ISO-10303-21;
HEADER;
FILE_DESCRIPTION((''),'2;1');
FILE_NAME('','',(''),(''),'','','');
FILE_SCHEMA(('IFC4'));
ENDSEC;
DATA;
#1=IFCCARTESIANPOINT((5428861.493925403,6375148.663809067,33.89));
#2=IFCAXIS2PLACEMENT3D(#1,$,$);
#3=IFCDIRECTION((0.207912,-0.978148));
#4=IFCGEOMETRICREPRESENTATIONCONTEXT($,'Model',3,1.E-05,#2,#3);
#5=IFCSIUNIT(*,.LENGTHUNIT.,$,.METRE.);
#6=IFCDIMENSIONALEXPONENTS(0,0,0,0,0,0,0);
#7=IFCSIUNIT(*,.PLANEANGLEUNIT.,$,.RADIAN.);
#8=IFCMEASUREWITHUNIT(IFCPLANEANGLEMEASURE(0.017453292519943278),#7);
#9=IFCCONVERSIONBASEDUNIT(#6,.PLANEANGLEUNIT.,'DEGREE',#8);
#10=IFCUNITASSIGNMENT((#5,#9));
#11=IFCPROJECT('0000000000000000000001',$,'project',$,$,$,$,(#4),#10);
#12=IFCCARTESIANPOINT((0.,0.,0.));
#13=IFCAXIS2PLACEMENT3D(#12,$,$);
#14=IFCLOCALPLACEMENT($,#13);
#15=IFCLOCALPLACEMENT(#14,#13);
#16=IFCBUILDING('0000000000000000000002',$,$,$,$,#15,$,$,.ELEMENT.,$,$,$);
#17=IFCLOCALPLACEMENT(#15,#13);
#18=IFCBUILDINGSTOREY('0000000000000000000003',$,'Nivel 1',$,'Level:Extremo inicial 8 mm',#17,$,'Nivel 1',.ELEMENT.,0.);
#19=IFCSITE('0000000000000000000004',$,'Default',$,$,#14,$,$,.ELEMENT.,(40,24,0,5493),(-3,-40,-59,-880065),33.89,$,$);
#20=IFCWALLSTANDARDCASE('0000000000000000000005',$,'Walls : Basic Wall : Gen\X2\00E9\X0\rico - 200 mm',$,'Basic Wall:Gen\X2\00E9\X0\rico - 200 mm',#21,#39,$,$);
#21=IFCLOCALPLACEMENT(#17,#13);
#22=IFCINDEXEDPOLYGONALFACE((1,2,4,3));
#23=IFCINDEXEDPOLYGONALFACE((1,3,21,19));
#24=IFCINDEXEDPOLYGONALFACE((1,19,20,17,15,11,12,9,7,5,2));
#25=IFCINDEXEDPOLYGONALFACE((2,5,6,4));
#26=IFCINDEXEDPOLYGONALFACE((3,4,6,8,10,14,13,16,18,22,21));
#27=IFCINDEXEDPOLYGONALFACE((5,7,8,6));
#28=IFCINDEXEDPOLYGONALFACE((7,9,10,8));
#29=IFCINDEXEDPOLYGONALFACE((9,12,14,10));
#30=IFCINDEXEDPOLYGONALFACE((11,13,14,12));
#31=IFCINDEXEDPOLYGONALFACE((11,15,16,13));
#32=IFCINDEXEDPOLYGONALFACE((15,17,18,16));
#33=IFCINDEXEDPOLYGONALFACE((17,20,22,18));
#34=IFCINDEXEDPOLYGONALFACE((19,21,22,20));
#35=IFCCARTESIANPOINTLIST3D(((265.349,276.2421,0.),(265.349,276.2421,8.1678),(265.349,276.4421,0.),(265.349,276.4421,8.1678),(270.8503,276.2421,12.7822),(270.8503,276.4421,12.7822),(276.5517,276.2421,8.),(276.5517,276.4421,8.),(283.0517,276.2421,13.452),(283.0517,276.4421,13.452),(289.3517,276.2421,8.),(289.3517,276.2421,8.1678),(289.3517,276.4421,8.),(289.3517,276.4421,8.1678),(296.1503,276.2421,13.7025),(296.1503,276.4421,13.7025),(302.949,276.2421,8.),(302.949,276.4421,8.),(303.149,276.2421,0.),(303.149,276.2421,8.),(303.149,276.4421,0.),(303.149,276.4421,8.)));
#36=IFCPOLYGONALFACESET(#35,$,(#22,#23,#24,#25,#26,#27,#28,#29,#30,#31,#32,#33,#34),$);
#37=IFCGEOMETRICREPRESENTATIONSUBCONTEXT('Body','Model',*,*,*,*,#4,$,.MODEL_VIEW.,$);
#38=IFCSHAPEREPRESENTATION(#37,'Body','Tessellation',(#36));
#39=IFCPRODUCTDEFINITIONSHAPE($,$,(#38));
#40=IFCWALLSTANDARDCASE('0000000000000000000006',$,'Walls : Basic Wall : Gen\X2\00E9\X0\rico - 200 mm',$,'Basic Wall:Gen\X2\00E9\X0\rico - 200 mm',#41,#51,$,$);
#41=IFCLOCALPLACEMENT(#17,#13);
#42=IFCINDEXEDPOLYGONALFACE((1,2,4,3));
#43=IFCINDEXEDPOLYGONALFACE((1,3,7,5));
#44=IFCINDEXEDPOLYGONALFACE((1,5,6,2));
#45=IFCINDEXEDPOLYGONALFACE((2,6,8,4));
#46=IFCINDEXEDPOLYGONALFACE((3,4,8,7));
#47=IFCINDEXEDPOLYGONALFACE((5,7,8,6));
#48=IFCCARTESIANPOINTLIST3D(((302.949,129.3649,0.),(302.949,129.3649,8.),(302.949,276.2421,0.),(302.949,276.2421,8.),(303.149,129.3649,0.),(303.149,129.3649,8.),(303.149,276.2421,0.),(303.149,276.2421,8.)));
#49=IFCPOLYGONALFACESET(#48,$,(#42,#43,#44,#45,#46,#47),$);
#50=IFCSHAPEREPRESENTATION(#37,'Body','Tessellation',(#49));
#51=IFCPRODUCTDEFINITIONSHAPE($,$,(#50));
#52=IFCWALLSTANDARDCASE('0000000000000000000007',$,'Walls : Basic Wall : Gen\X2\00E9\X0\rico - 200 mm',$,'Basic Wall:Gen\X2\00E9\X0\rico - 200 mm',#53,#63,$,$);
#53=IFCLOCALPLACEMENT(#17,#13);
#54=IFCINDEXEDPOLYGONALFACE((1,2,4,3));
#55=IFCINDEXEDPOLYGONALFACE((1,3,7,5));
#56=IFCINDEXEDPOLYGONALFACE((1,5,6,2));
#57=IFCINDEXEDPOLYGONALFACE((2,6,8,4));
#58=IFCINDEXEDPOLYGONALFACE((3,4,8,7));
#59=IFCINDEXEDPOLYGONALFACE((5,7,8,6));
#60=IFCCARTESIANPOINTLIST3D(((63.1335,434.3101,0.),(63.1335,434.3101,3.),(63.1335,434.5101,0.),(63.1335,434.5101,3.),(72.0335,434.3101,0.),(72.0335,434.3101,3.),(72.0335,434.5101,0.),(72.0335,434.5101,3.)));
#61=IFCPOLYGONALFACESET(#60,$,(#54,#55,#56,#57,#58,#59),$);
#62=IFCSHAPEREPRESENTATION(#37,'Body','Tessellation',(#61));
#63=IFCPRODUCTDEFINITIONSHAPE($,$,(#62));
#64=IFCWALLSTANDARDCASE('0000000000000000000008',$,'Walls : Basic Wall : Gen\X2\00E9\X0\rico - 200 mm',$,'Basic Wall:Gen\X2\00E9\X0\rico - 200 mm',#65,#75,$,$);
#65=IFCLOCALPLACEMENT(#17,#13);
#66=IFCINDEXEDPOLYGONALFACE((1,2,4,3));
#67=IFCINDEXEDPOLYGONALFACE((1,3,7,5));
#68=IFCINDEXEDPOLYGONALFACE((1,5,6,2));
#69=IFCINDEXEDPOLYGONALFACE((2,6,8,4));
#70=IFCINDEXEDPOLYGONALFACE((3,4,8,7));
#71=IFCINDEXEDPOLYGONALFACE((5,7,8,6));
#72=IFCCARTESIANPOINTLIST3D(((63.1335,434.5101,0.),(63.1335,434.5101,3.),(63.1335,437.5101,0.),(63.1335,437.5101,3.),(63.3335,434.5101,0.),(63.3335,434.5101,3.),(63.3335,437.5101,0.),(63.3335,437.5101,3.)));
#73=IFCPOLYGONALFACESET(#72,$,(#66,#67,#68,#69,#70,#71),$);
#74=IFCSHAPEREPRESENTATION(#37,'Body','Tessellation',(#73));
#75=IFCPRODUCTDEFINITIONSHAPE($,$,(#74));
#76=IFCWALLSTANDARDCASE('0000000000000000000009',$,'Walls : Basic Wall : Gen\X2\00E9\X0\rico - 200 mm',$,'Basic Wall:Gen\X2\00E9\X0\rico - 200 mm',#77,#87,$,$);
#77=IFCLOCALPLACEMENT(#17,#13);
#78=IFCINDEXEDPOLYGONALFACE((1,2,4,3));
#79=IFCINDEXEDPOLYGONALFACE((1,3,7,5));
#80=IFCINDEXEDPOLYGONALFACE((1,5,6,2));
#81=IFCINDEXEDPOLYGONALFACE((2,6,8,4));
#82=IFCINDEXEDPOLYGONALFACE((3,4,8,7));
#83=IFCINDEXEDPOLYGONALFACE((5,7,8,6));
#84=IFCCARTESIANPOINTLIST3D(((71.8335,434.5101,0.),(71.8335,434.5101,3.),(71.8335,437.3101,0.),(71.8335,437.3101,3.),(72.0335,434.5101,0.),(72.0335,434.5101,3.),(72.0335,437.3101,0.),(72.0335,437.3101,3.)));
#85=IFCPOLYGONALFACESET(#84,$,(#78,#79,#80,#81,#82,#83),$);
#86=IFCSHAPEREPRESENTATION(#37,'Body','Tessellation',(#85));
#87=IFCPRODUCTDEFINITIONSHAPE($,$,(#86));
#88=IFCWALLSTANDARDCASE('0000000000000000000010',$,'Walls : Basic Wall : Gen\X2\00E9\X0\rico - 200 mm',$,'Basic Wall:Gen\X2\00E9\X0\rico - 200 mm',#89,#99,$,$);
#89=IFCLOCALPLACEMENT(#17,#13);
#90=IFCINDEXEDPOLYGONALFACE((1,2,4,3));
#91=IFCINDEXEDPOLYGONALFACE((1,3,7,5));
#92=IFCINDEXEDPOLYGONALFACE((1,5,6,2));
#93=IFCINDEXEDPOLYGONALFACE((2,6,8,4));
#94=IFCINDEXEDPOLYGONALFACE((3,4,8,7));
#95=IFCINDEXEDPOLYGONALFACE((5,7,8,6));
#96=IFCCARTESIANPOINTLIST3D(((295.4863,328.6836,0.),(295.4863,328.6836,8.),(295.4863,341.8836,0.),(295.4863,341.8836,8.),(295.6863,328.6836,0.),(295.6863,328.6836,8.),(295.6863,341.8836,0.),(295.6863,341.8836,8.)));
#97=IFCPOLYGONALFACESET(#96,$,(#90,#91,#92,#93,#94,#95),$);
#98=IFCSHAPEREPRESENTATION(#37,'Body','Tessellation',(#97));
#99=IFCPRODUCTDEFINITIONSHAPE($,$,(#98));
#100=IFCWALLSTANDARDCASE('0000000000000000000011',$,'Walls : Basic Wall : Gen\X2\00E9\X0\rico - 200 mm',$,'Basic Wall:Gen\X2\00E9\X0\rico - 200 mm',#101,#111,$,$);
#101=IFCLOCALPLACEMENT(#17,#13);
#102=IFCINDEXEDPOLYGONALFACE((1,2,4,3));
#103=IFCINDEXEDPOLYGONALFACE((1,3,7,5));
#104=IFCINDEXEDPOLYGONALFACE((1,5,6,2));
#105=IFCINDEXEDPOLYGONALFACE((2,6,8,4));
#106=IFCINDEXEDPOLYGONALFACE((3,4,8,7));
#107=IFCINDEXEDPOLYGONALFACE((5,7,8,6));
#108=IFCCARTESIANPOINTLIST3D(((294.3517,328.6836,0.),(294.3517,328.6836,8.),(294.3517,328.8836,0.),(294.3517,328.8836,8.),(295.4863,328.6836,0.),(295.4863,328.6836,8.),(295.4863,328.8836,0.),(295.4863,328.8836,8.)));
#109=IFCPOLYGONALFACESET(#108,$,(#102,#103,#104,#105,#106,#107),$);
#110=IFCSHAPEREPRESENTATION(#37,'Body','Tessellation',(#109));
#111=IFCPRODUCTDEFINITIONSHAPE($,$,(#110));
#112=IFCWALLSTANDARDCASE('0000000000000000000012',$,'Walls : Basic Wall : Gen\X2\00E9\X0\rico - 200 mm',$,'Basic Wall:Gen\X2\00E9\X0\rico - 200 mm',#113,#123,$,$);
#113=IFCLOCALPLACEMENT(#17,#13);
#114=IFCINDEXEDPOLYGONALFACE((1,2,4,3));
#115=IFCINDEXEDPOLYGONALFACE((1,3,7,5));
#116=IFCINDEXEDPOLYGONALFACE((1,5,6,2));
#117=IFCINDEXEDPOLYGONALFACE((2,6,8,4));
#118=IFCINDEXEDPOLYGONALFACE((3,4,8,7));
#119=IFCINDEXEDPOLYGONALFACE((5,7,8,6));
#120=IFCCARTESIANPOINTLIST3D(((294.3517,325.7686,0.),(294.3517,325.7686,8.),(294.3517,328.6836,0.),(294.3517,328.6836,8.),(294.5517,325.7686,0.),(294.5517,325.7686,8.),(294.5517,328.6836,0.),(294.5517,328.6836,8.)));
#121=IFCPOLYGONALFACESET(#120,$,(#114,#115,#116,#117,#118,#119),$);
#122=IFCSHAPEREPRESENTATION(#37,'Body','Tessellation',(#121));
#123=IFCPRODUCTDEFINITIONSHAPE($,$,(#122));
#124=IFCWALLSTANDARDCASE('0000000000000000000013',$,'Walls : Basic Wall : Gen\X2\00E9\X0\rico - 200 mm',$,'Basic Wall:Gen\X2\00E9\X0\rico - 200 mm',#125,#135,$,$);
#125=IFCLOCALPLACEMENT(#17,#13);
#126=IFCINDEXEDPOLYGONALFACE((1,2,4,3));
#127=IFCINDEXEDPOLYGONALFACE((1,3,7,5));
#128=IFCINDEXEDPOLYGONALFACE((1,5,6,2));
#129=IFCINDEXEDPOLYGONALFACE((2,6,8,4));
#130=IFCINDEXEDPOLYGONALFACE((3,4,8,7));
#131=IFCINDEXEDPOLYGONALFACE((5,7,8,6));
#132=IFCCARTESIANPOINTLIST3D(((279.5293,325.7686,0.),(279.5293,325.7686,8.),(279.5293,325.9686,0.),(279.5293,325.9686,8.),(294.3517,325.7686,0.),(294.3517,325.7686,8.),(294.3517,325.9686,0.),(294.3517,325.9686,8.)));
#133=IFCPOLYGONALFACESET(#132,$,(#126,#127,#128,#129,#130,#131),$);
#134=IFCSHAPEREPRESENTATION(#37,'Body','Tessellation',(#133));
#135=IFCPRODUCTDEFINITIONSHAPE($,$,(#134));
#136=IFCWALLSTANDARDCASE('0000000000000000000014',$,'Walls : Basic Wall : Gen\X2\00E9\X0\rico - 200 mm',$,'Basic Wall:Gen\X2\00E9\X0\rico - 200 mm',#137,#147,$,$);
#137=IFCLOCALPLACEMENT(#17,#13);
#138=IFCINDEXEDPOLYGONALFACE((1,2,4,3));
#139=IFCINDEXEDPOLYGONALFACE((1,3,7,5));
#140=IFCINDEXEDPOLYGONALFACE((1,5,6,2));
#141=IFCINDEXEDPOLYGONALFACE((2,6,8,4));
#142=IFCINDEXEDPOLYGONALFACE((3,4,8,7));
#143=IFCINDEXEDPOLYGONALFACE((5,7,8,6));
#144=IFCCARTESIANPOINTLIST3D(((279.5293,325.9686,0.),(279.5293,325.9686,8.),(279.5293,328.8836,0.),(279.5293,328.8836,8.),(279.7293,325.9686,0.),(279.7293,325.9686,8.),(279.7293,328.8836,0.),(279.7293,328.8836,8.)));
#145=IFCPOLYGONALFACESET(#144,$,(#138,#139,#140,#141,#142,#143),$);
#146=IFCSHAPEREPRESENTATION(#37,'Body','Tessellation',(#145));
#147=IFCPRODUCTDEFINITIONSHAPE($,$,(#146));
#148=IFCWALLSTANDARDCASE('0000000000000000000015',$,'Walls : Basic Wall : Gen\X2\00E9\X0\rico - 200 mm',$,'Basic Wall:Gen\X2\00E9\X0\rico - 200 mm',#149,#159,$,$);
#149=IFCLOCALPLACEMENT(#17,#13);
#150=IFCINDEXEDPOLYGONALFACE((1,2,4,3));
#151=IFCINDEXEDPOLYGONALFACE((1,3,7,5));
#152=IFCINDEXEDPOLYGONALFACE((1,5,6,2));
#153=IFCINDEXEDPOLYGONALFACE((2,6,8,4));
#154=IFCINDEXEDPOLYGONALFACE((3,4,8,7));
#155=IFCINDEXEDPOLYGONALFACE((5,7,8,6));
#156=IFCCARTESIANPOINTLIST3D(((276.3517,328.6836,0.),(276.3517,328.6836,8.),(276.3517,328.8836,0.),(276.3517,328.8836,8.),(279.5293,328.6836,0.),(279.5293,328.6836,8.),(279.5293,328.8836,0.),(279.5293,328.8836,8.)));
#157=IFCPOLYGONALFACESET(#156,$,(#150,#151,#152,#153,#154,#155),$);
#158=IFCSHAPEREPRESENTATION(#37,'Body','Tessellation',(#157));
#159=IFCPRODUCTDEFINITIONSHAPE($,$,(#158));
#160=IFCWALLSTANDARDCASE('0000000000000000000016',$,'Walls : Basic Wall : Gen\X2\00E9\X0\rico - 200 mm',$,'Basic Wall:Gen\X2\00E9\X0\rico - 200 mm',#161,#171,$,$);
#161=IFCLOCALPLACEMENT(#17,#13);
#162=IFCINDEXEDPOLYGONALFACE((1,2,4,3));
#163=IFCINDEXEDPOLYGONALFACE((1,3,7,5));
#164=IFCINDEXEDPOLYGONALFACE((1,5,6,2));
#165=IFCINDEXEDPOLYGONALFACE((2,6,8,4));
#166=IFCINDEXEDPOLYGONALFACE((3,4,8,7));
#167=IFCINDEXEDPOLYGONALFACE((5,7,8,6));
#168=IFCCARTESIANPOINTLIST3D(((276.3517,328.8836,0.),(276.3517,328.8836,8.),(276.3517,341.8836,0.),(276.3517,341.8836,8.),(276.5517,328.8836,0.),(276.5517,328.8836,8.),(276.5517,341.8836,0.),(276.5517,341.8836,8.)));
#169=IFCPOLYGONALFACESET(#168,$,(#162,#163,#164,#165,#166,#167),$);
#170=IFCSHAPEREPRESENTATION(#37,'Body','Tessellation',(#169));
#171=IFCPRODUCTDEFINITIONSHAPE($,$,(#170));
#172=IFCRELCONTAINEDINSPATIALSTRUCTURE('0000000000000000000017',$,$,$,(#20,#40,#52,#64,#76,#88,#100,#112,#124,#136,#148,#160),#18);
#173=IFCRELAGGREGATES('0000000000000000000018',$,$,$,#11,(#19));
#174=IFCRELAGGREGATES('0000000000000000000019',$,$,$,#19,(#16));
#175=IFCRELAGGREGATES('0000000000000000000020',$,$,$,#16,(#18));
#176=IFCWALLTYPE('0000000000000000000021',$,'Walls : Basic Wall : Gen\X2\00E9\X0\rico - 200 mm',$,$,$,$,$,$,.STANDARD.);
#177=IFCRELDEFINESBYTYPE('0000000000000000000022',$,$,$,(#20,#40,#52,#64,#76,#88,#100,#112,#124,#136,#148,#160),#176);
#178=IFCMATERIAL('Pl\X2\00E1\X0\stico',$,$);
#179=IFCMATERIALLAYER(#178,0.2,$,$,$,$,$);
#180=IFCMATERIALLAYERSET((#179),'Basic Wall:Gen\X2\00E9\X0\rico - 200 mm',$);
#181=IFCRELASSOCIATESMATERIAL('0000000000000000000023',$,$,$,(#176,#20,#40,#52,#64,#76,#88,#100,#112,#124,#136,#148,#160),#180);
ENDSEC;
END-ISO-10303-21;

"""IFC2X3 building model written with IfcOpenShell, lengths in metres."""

from ifc_helpers import new_model, entity, si_unit, converted_unit, direction, frame, frame_2d, origin, place, context, subcontext, project, spatial, polyline, rectangle, extrude, clip, bounded_halfspace, material, layer, layer_set, layer_usage, type_object, element, save


model = new_model("IFC2X3")

# Units and contexts
model_context = context("Model", 3, precision=1e-05, world=frame((5428861.493925403, 6375148.663809067, 33.89)), true_north=direction((0.207912, -0.978148)))
body_context = subcontext(model_context, "Body", "Model", "MODEL_VIEW")
ifc_project = project(units=[si_unit("LENGTHUNIT", "METRE"), converted_unit("PLANEANGLEUNIT", "DEGREE", entity("IfcPlaneAngleMeasure", 0.017453292519943278), si_unit("PLANEANGLEUNIT", "RADIAN"), dimensions=[0, 0, 0, 0, 0, 0, 0])], contexts=[model_context])

# Site, building, storey
site_placement = place(None, origin())
site = spatial("IfcSite", under=ifc_project, at=site_placement, Name="Default", CompositionType="ELEMENT", RefLatitude=(40, 24, 0, 5493), RefLongitude=(-3, -40, -59, -880065), RefElevation=33.89)
building_placement = place(site_placement, origin())
building = spatial("IfcBuilding", under=site, at=building_placement, CompositionType="ELEMENT")
storey_placement = place(building_placement, origin())
storey = spatial("IfcBuildingStorey", under=building, at=storey_placement, Name="Nivel 1", ObjectType="Level:Extremo inicial 8 mm", LongName="Nivel 1", CompositionType="ELEMENT", Elevation=0.0)

# Walls
ifc_material_1 = material(Name="Plástico")
ifc_layer_1 = layer(ifc_material_1, 0.2)
ifc_layer_set_1 = layer_set([ifc_layer_1], Name="Basic Wall:Genérico - 200 mm")
ifc_layer_usage_1 = layer_usage(ifc_layer_set_1, "AXIS2", "NEGATIVE", 0.1)
wall_type = type_object("IfcWallType", Name="Walls : Basic Wall : Genérico - 200 mm", PredefinedType="STANDARD", material=ifc_layer_set_1)
wall_1_placement = place(storey_placement, frame((265.349, 276.3421, 0.0)))
element("IfcWallStandardCase", 1, at=wall_1_placement, inside=storey, type_object=wall_type, material=ifc_layer_usage_1, Name="Walls : Basic Wall : Genérico - 200 mm", ObjectType="Basic Wall:Genérico - 200 mm", context=body_context, shape_type="Clipping", body=[
    clip(clip(clip(clip(clip(clip(clip(extrude(rectangle(XDim=37.8, YDim=0.2, at=frame_2d((18.9, 0.0), x_axis=(-1.0, 0.0))), origin(), (0.0, 0.0, 1.0), 13.7025), bounded_halfspace(frame((0.0, -0.1, 8.1678), z_axis=(-0.642641, 0.0, 0.766167), x_axis=(0.0, -1.0, 0.0)), False, frame((0.0, -0.1, 8.1678)), polyline([(0.0, 0.0), (5.5014, 0.0), (5.5014, 0.2), (0.0, 0.2), (0.0, 0.0)]))), bounded_halfspace(frame((11.2027, -0.1, 8.0), z_axis=(-0.642641, 0.0, 0.766167), x_axis=(0.0, -1.0, 0.0)), False, frame((11.2027, -0.1, 8.0)), polyline([(0.0, 0.0), (6.5, 0.0), (6.5, 0.2), (0.0, 0.2), (0.0, 0.0)]))), bounded_halfspace(frame((30.8014, 0.1, 13.7025), z_axis=(-0.642641, 0.0, 0.766167), x_axis=(0.0, -1.0, 0.0)), False, frame((30.8014, 0.1, 13.7025)), polyline([(0.0, 0.0), (-6.7986, 0.0), (-6.7986, -0.2), (0.0, -0.2), (0.0, 0.0)]))), bounded_halfspace(frame((5.5014, -0.1, 12.7822), z_axis=(0.642641, 0.0, 0.766167), x_axis=(0.0, 1.0, 0.0)), False, frame((5.5014, -0.1, 12.7822)), polyline([(0.0, 0.0), (5.7014, 0.0), (5.7014, 0.2), (0.0, 0.2), (0.0, 0.0)]))), bounded_halfspace(frame((17.7027, -0.1, 13.452), z_axis=(0.642641, 0.0, 0.766167), x_axis=(0.0, 1.0, 0.0)), False, frame((17.7027, -0.1, 13.452)), polyline([(0.0, 0.0), (6.3, 0.0), (6.3, 0.2), (0.0, 0.2), (0.0, 0.0)]))), bounded_halfspace(frame((37.6, -0.1, 8.0), z_axis=(0.642641, 0.0, 0.766167), x_axis=(0.0, 1.0, 0.0)), False, frame((37.6, -0.1, 8.0)), polyline([(0.0, 0.0), (0.0, 0.2), (-6.7986, 0.2), (-6.7986, 0.0), (0.0, 0.0)]))), bounded_halfspace(frame((37.6, -0.1, 8.0), z_axis=(0.0, 0.0, 1.0), x_axis=(0.0, 1.0, 0.0)), False, frame((37.6, -0.1, 8.0)), polyline([(0.0, 0.0), (0.2, 0.0), (0.2, 0.2), (0.0, 0.2), (0.0, 0.0)]))),
])
ifc_layer_usage_2 = layer_usage(ifc_layer_set_1, "AXIS2", "NEGATIVE", 0.1)
wall_2_placement = place(storey_placement, frame((303.049, 276.2421, 0.0), z_axis=(0.0, 0.0, 1.0), x_axis=(0.0, -1.0, 0.0)))
element("IfcWallStandardCase", 2, at=wall_2_placement, inside=storey, type_object=wall_type, material=ifc_layer_usage_2, Name="Walls : Basic Wall : Genérico - 200 mm", ObjectType="Basic Wall:Genérico - 200 mm", context=body_context, shape_type="SweptSolid", body=[
    extrude(rectangle(XDim=146.8772, YDim=0.2, at=frame_2d((73.4386, 0.0), x_axis=(-1.0, 0.0))), origin(), (0.0, 0.0, 1.0), 8.0),
])
ifc_layer_usage_3 = layer_usage(ifc_layer_set_1, "AXIS2", "NEGATIVE", 0.1)
wall_3_placement = place(storey_placement, frame((72.0335, 434.4101, 0.0), z_axis=(0.0, 0.0, 1.0), x_axis=(-1.0, 0.0, 0.0)))
element("IfcWallStandardCase", 3, at=wall_3_placement, inside=storey, type_object=wall_type, material=ifc_layer_usage_3, Name="Walls : Basic Wall : Genérico - 200 mm", ObjectType="Basic Wall:Genérico - 200 mm", context=body_context, shape_type="SweptSolid", body=[
    extrude(rectangle(XDim=8.9, YDim=0.2, at=frame_2d((4.45, 0.0), x_axis=(-1.0, 0.0))), origin(), (0.0, 0.0, 1.0), 3.0),
])
ifc_layer_usage_4 = layer_usage(ifc_layer_set_1, "AXIS2", "POSITIVE", -0.1)
wall_4_placement = place(storey_placement, frame((63.2335, 434.5101, 0.0), z_axis=(0.0, 0.0, 1.0), x_axis=(0.0, 1.0, 0.0)))
element("IfcWallStandardCase", 4, at=wall_4_placement, inside=storey, type_object=wall_type, material=ifc_layer_usage_4, Name="Walls : Basic Wall : Genérico - 200 mm", ObjectType="Basic Wall:Genérico - 200 mm", context=body_context, shape_type="SweptSolid", body=[
    extrude(rectangle(XDim=3.0, YDim=0.2, at=frame_2d((1.5, 0.0), x_axis=(-1.0, 0.0))), origin(), (0.0, 0.0, 1.0), 3.0),
])
ifc_layer_usage_5 = layer_usage(ifc_layer_set_1, "AXIS2", "NEGATIVE", 0.1)
wall_5_placement = place(storey_placement, frame((71.9335, 437.3101, 0.0), z_axis=(0.0, 0.0, 1.0), x_axis=(0.0, -1.0, 0.0)))
element("IfcWallStandardCase", 5, at=wall_5_placement, inside=storey, type_object=wall_type, material=ifc_layer_usage_5, Name="Walls : Basic Wall : Genérico - 200 mm", ObjectType="Basic Wall:Genérico - 200 mm", context=body_context, shape_type="SweptSolid", body=[
    extrude(rectangle(XDim=2.8, YDim=0.2, at=frame_2d((1.4, 0.0), x_axis=(-1.0, 0.0))), origin(), (0.0, 0.0, 1.0), 3.0),
])
ifc_layer_usage_6 = layer_usage(ifc_layer_set_1, "AXIS2", "NEGATIVE", 0.1)
wall_6_placement = place(storey_placement, frame((295.5863, 341.8836, 0.0), z_axis=(0.0, 0.0, 1.0), x_axis=(0.0, -1.0, 0.0)))
element("IfcWallStandardCase", 6, at=wall_6_placement, inside=storey, type_object=wall_type, material=ifc_layer_usage_6, Name="Walls : Basic Wall : Genérico - 200 mm", ObjectType="Basic Wall:Genérico - 200 mm", context=body_context, shape_type="SweptSolid", body=[
    extrude(rectangle(XDim=13.2, YDim=0.2, at=frame_2d((6.6, 0.0), x_axis=(-1.0, 0.0))), origin(), (0.0, 0.0, 1.0), 8.0),
])
ifc_layer_usage_7 = layer_usage(ifc_layer_set_1, "AXIS2", "NEGATIVE", 0.1)
wall_7_placement = place(storey_placement, frame((295.4863, 328.7836, 0.0), z_axis=(0.0, 0.0, 1.0), x_axis=(-1.0, 0.0, 0.0)))
element("IfcWallStandardCase", 7, at=wall_7_placement, inside=storey, type_object=wall_type, material=ifc_layer_usage_7, Name="Walls : Basic Wall : Genérico - 200 mm", ObjectType="Basic Wall:Genérico - 200 mm", context=body_context, shape_type="SweptSolid", body=[
    extrude(rectangle(XDim=1.1346, YDim=0.2, at=frame_2d((0.5673, 0.0), x_axis=(-1.0, 0.0))), origin(), (0.0, 0.0, 1.0), 8.0),
])
ifc_layer_usage_8 = layer_usage(ifc_layer_set_1, "AXIS2", "NEGATIVE", 0.1)
wall_8_placement = place(storey_placement, frame((294.4517, 328.6836, 0.0), z_axis=(0.0, 0.0, 1.0), x_axis=(0.0, -1.0, 0.0)))
element("IfcWallStandardCase", 8, at=wall_8_placement, inside=storey, type_object=wall_type, material=ifc_layer_usage_8, Name="Walls : Basic Wall : Genérico - 200 mm", ObjectType="Basic Wall:Genérico - 200 mm", context=body_context, shape_type="SweptSolid", body=[
    extrude(rectangle(XDim=2.915, YDim=0.2, at=frame_2d((1.4575, 0.0), x_axis=(-1.0, 0.0))), origin(), (0.0, 0.0, 1.0), 8.0),
])
ifc_layer_usage_9 = layer_usage(ifc_layer_set_1, "AXIS2", "NEGATIVE", 0.1)
wall_9_placement = place(storey_placement, frame((294.3517, 325.8686, 0.0), z_axis=(0.0, 0.0, 1.0), x_axis=(-1.0, 0.0, 0.0)))
element("IfcWallStandardCase", 9, at=wall_9_placement, inside=storey, type_object=wall_type, material=ifc_layer_usage_9, Name="Walls : Basic Wall : Genérico - 200 mm", ObjectType="Basic Wall:Genérico - 200 mm", context=body_context, shape_type="SweptSolid", body=[
    extrude(rectangle(XDim=14.8224, YDim=0.2, at=frame_2d((7.4112, 0.0), x_axis=(-1.0, 0.0))), origin(), (0.0, 0.0, 1.0), 8.0),
])
ifc_layer_usage_10 = layer_usage(ifc_layer_set_1, "AXIS2", "NEGATIVE", 0.1)
wall_10_placement = place(storey_placement, frame((279.6293, 325.9686, 0.0), z_axis=(0.0, 0.0, 1.0), x_axis=(0.0, 1.0, 0.0)))
element("IfcWallStandardCase", 10, at=wall_10_placement, inside=storey, type_object=wall_type, material=ifc_layer_usage_10, Name="Walls : Basic Wall : Genérico - 200 mm", ObjectType="Basic Wall:Genérico - 200 mm", context=body_context, shape_type="SweptSolid", body=[
    extrude(rectangle(XDim=2.915, YDim=0.2, at=frame_2d((1.4575, 0.0), x_axis=(-1.0, 0.0))), origin(), (0.0, 0.0, 1.0), 8.0),
])
ifc_layer_usage_11 = layer_usage(ifc_layer_set_1, "AXIS2", "NEGATIVE", 0.1)
wall_11_placement = place(storey_placement, frame((279.5293, 328.7836, 0.0), z_axis=(0.0, 0.0, 1.0), x_axis=(-1.0, 0.0, 0.0)))
element("IfcWallStandardCase", 11, at=wall_11_placement, inside=storey, type_object=wall_type, material=ifc_layer_usage_11, Name="Walls : Basic Wall : Genérico - 200 mm", ObjectType="Basic Wall:Genérico - 200 mm", context=body_context, shape_type="SweptSolid", body=[
    extrude(rectangle(XDim=3.1776, YDim=0.2, at=frame_2d((1.5888, 0.0), x_axis=(-1.0, 0.0))), origin(), (0.0, 0.0, 1.0), 8.0),
])
ifc_layer_usage_12 = layer_usage(ifc_layer_set_1, "AXIS2", "NEGATIVE", 0.1)
wall_12_placement = place(storey_placement, frame((276.4517, 328.8836, 0.0), z_axis=(0.0, 0.0, 1.0), x_axis=(0.0, 1.0, 0.0)))
element("IfcWallStandardCase", 12, at=wall_12_placement, inside=storey, type_object=wall_type, material=ifc_layer_usage_12, Name="Walls : Basic Wall : Genérico - 200 mm", ObjectType="Basic Wall:Genérico - 200 mm", context=body_context, shape_type="SweptSolid", body=[
    extrude(rectangle(XDim=13.0, YDim=0.2, at=frame_2d((6.5, 0.0), x_axis=(-1.0, 0.0))), origin(), (0.0, 0.0, 1.0), 8.0),
])

save(model, "model.ifc")
